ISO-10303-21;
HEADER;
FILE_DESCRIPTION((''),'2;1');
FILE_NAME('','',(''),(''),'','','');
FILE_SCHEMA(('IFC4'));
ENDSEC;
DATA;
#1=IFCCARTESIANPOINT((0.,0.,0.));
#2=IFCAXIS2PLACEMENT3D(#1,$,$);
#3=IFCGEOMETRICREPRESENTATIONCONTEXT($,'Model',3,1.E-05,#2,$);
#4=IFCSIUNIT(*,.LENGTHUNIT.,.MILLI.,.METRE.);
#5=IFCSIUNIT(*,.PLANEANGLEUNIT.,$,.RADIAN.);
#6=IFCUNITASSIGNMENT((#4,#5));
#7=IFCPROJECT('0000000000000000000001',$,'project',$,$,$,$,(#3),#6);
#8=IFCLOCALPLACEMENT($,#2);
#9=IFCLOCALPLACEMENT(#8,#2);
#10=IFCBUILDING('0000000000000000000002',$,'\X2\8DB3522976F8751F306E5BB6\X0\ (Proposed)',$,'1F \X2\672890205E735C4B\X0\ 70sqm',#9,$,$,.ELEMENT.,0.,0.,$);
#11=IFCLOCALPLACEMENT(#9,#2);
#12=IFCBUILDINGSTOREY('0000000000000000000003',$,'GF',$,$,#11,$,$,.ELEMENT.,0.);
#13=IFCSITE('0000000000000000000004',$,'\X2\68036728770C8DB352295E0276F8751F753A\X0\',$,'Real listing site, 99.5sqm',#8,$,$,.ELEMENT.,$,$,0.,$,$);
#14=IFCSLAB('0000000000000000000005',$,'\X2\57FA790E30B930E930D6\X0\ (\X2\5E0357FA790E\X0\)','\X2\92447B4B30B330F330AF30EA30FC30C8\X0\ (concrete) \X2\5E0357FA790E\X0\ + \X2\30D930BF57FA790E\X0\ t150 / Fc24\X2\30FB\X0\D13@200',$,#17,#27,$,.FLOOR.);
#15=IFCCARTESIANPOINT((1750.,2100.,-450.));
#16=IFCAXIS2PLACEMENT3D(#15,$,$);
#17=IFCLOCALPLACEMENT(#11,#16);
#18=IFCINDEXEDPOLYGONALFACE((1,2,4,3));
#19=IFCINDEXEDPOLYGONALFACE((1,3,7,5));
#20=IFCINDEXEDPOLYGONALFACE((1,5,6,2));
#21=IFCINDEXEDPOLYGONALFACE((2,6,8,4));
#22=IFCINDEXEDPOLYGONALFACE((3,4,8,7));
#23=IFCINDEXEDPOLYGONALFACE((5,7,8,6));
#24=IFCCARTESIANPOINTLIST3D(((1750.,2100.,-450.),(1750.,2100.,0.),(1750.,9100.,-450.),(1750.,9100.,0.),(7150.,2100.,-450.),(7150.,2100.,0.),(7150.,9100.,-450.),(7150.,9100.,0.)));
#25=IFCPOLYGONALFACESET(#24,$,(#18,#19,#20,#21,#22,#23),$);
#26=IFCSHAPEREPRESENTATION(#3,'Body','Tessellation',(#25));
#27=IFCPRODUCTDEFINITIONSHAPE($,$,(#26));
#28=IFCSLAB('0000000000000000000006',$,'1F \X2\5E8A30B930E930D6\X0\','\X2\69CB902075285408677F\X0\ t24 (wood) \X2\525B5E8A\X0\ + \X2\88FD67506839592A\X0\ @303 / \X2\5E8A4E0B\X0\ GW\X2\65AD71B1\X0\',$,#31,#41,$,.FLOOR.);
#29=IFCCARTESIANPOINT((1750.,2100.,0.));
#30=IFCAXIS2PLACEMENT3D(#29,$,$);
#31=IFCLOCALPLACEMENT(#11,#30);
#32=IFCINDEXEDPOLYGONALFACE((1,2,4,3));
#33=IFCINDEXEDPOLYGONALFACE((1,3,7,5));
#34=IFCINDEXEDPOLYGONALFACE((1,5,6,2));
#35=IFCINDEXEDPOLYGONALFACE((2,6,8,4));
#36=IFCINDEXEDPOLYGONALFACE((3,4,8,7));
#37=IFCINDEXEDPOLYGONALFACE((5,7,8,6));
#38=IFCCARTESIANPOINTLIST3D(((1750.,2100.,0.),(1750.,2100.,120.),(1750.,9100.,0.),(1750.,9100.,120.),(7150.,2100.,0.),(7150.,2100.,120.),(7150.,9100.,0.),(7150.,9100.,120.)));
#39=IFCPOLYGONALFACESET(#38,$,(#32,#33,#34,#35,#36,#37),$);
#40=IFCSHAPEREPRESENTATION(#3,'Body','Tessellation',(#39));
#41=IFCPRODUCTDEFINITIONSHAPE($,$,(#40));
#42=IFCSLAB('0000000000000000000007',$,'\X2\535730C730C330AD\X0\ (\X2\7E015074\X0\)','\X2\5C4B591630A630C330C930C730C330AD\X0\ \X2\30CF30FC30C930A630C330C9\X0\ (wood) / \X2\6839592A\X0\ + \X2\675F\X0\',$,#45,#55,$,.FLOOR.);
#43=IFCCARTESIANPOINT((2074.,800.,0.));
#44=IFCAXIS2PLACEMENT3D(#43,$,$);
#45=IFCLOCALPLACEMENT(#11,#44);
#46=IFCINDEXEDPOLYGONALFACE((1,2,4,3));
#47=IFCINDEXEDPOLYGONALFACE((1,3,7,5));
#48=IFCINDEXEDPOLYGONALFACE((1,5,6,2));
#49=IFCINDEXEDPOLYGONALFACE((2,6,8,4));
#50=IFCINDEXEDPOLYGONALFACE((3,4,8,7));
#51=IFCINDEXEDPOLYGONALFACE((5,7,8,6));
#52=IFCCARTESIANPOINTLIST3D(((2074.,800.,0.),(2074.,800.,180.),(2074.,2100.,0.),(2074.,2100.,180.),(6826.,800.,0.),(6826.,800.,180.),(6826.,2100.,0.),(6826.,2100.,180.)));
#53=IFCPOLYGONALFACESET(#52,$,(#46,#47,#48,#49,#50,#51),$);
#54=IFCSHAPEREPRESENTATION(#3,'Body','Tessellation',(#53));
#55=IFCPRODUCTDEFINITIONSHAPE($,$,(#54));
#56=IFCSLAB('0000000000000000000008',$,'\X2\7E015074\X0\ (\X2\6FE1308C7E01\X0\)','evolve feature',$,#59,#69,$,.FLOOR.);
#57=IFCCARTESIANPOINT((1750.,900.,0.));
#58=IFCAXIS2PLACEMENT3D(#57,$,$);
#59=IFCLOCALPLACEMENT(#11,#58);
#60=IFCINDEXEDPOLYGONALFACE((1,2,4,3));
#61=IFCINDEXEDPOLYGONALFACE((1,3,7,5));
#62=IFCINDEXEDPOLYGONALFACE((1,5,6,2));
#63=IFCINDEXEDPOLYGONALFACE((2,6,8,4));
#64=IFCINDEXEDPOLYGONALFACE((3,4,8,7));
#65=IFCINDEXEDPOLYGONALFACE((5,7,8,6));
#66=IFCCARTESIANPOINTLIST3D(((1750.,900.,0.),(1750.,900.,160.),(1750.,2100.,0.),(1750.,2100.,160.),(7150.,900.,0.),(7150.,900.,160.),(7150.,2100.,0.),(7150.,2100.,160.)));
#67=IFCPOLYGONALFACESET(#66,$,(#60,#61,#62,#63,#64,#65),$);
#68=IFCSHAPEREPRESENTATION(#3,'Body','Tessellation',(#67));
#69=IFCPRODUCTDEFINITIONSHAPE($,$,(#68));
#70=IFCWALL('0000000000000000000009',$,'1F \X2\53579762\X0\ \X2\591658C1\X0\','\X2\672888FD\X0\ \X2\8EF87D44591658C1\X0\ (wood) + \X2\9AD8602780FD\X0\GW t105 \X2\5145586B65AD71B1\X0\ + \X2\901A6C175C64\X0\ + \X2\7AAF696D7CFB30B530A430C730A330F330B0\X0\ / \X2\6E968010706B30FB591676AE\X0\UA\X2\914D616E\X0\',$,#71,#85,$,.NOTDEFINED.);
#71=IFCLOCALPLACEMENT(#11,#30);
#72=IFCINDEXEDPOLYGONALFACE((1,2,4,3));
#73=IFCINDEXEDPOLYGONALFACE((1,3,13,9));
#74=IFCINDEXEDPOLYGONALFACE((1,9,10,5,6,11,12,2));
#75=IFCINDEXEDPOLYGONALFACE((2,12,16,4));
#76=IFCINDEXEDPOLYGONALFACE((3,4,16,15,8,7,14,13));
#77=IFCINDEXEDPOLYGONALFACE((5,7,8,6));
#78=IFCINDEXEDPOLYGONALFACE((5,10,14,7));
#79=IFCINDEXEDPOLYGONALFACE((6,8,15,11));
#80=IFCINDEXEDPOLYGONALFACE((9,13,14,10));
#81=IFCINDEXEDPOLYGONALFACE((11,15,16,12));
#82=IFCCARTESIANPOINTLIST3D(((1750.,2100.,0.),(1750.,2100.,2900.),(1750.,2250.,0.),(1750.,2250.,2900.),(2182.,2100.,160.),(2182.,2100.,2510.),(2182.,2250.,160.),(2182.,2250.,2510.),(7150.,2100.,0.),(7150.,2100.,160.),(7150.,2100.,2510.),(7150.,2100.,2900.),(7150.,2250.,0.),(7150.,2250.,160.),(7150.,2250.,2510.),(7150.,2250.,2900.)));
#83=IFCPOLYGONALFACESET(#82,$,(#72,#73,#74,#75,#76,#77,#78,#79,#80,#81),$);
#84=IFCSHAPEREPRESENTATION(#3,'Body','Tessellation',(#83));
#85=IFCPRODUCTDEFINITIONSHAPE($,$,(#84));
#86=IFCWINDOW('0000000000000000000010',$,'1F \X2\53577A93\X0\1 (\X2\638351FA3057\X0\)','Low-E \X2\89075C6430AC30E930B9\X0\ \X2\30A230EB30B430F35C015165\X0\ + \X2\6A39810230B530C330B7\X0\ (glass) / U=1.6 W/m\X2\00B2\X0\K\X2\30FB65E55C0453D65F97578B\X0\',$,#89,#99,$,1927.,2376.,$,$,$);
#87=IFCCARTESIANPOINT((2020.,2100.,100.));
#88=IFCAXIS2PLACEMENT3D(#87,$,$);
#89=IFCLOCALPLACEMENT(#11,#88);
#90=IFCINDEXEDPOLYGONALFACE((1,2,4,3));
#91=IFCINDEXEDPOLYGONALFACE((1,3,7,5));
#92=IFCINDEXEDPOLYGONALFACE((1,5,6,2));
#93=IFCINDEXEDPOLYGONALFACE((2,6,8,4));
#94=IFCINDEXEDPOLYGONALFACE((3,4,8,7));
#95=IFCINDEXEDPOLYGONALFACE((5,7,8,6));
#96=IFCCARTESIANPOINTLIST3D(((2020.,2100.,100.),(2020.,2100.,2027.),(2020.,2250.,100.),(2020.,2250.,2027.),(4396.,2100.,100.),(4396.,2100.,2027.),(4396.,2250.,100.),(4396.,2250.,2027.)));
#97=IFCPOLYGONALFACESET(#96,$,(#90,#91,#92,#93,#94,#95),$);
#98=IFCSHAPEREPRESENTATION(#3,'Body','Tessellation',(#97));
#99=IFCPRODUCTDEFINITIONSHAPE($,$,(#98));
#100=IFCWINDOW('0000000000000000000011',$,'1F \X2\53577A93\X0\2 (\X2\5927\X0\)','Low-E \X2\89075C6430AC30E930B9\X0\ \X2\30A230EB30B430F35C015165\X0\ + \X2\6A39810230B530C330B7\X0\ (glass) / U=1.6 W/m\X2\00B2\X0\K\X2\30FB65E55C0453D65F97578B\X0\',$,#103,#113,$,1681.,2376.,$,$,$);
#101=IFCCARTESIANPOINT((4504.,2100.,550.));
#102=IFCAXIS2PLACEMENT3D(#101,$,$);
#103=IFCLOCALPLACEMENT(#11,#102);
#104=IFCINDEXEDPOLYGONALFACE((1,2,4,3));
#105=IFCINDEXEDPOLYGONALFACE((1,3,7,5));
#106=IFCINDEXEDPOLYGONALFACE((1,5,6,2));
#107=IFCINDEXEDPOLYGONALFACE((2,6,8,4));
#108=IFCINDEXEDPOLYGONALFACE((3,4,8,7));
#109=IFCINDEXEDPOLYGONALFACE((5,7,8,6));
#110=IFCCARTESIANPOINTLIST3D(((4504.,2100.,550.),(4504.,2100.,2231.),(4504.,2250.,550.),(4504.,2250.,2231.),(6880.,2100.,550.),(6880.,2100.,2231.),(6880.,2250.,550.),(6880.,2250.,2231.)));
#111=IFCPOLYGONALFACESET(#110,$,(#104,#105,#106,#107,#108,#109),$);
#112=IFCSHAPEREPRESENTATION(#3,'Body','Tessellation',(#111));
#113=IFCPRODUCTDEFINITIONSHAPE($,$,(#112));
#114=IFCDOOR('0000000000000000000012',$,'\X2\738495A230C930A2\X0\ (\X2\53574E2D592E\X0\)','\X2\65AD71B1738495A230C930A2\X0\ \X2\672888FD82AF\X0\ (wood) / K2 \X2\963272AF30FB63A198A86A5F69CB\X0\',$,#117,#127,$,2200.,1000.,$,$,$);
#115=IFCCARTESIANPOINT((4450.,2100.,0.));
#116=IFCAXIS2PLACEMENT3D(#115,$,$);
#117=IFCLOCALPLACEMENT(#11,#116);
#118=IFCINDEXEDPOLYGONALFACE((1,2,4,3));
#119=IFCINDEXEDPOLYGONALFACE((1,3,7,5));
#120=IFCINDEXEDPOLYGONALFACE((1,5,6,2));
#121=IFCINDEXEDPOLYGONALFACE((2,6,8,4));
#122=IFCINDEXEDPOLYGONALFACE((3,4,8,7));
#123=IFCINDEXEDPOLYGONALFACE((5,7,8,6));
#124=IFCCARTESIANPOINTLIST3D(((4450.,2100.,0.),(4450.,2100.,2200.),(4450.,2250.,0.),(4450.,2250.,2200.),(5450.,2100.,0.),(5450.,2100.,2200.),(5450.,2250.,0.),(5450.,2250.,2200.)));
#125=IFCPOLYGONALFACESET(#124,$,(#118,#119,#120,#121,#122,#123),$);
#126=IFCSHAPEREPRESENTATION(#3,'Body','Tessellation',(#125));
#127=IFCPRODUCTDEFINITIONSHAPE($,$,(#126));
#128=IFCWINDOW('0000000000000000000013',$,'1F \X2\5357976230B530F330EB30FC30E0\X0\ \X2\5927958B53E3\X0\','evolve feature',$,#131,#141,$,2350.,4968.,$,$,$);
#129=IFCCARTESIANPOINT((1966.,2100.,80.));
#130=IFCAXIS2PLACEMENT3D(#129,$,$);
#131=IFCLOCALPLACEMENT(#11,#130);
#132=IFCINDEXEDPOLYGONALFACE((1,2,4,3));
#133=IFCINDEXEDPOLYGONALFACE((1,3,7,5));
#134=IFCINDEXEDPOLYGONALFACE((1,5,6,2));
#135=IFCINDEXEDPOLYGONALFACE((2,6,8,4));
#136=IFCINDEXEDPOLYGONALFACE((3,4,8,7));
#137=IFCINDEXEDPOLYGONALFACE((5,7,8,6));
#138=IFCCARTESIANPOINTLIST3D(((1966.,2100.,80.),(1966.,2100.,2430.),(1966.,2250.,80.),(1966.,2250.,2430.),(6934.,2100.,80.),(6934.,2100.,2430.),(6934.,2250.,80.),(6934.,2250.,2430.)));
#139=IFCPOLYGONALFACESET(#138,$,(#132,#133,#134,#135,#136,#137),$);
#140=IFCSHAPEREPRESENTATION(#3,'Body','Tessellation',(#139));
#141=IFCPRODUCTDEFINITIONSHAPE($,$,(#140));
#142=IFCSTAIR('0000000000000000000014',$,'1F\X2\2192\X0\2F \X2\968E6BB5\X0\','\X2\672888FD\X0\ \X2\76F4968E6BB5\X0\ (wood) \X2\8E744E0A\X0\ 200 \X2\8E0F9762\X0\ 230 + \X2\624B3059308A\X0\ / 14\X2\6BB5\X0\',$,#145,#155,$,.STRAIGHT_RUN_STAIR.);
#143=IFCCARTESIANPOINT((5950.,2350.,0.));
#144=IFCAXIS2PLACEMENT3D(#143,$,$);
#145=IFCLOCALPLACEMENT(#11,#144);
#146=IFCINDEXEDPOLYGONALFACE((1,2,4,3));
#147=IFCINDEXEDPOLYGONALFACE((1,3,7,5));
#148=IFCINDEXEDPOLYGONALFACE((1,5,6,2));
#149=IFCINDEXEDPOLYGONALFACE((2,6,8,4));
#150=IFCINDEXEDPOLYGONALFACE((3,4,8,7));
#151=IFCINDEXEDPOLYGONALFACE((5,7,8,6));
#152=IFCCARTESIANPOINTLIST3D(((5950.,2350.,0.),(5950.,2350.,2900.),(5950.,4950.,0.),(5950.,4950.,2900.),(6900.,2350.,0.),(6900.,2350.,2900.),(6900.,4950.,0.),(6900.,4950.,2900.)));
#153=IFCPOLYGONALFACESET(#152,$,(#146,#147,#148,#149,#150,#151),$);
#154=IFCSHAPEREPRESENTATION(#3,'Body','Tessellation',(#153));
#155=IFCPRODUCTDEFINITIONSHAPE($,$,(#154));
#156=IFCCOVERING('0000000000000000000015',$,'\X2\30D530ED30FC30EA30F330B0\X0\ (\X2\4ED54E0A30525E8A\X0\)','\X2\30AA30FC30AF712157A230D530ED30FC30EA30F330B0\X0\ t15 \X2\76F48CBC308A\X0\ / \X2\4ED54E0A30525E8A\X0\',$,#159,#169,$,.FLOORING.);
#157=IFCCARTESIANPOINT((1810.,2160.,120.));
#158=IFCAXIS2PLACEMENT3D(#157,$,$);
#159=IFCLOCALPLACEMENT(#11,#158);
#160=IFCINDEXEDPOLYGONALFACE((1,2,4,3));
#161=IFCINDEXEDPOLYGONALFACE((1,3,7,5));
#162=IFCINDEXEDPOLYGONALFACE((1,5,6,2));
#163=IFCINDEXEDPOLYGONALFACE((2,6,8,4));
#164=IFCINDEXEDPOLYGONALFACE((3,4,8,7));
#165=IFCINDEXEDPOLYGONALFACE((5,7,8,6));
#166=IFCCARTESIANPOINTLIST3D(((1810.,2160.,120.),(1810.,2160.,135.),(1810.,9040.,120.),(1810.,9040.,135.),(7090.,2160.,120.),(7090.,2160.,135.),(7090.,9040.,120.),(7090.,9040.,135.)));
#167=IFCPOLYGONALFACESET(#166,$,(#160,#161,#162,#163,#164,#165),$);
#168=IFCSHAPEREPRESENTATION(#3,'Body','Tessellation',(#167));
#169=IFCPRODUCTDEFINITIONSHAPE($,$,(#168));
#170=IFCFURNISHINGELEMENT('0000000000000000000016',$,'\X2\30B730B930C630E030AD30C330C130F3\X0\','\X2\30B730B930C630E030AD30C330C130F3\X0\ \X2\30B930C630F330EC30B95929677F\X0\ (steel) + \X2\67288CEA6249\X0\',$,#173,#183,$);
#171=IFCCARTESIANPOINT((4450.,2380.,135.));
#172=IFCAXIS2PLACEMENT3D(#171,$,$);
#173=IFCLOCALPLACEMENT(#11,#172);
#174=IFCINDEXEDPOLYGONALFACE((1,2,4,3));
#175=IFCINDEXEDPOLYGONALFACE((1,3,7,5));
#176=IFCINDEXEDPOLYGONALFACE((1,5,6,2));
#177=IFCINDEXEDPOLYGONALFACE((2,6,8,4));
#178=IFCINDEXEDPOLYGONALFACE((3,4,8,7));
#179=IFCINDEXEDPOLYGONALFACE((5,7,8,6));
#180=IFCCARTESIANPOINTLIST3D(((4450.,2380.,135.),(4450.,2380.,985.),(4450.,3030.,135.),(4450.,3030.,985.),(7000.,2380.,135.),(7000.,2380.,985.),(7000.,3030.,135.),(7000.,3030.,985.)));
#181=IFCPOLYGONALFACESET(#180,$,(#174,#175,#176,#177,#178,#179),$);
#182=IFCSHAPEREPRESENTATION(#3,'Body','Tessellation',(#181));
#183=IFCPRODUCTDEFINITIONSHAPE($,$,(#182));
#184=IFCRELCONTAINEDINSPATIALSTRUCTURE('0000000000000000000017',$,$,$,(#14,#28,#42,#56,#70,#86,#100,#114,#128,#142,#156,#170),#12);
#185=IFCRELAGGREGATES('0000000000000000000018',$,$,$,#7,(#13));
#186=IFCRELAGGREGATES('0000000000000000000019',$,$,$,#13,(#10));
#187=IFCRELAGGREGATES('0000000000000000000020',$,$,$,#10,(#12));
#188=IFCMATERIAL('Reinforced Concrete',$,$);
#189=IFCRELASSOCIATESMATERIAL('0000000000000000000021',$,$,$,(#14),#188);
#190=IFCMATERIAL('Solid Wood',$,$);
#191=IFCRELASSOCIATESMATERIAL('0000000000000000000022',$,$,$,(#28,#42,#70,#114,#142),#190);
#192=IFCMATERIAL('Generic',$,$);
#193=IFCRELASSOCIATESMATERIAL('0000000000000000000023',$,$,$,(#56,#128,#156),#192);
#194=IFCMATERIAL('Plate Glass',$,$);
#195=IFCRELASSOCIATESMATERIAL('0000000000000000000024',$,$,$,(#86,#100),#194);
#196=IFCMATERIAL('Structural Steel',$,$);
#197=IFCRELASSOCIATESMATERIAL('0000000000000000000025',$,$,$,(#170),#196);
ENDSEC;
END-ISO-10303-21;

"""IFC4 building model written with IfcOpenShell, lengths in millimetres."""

from ifc_helpers import new_model, si_unit, frame, frame_2d, origin, place, context, project, spatial, rectangle, extrude, material, element, fill, save


model = new_model("IFC4")

# Units and contexts
model_context = context("Model", 3, precision=1e-05, world=origin())
ifc_project = project(units=[si_unit("LENGTHUNIT", "METRE", prefix="MILLI"), si_unit("PLANEANGLEUNIT", "RADIAN")], contexts=[model_context])

# Site, building, storey
site_placement = place(None, origin())
site = spatial("IfcSite", under=ifc_project, at=site_placement, Name="栃木県足利市相生町", ObjectType="Real listing site, 99.5sqm", CompositionType="ELEMENT", RefElevation=0.0)
building_placement = place(site_placement, origin())
building = spatial("IfcBuilding", under=site, at=building_placement, Name="足利相生の家 (Proposed)", ObjectType="1F 木造平屋 70sqm", CompositionType="ELEMENT", ElevationOfRefHeight=0.0, ElevationOfTerrain=0.0)
storey_placement = place(building_placement, origin())
storey = spatial("IfcBuildingStorey", under=building, at=storey_placement, Name="GF", CompositionType="ELEMENT", Elevation=0.0)

# Slabs
ifc_material_1 = material(Name="Reinforced Concrete")
slab_1_placement = place(storey_placement, frame((1750.0, 2100.0, -450.0)))
element("IfcSlab", 1, at=slab_1_placement, inside=storey, material=ifc_material_1, Name="基礎スラブ (布基礎)", Description="鉄筋コンクリート (concrete) 布基礎 + ベタ基礎 t150 / Fc24・D13@200", PredefinedType="FLOOR", context=model_context, shape_type="SweptSolid", body=[
    extrude(rectangle(XDim=5400.0, YDim=7000.0, at=frame_2d((2700.0, 3500.0))), frame((1750.0, 2100.0, -450.0)), (0.0, 0.0, 1.0), 450.0),
])
ifc_material_2 = material(Name="Solid Wood")
slab_2_placement = place(storey_placement, frame((1750.0, 2100.0, 0.0)))
element("IfcSlab", 2, at=slab_2_placement, inside=storey, material=ifc_material_2, Name="1F 床スラブ", Description="構造用合板 t24 (wood) 剛床 + 製材根太 @303 / 床下 GW断熱", PredefinedType="FLOOR", context=model_context, shape_type="SweptSolid", body=[
    extrude(rectangle(XDim=5400.0, YDim=7000.0, at=frame_2d((2700.0, 3500.0))), frame((1750.0, 2100.0, 0.0)), (0.0, 0.0, 1.0), 120.0),
])
slab_3_placement = place(storey_placement, frame((2074.0, 800.0, 0.0)))
element("IfcSlab", 3, at=slab_3_placement, inside=storey, material=ifc_material_2, Name="南デッキ (縁側)", Description="屋外ウッドデッキ ハードウッド (wood) / 根太 + 束", PredefinedType="FLOOR", context=model_context, shape_type="SweptSolid", body=[
    extrude(rectangle(XDim=4752.0, YDim=1300.0, at=frame_2d((2376.0, 650.0))), frame((2074.0, 800.0, 0.0)), (0.0, 0.0, 1.0), 180.0),
])
ifc_material_3 = material(Name="Generic")
slab_4_placement = place(storey_placement, frame((1750.0, 900.0, 0.0)))
element("IfcSlab", 4, at=slab_4_placement, inside=storey, material=ifc_material_3, Name="縁側 (濡れ縁)", Description="evolve feature", PredefinedType="FLOOR", context=model_context, shape_type="SweptSolid", body=[
    extrude(rectangle(XDim=5400.0, YDim=1200.0, at=frame_2d((2700.0, 600.0))), frame((1750.0, 900.0, 0.0)), (0.0, 0.0, 1.0), 160.0),
])

# Wall, openings, windows, door
wall_1_placement = place(storey_placement, frame((1750.0, 2100.0, 0.0)))
wall_1 = element("IfcWall", 5, at=wall_1_placement, inside=storey, material=ifc_material_2, Name="1F 南面 外壁", Description="木製 軸組外壁 (wood) + 高性能GW t105 充填断熱 + 通気層 + 窯業系サイディング / 準耐火・外皮UA配慮", PredefinedType="NOTDEFINED", context=model_context, shape_type="SweptSolid", body=[
    extrude(rectangle(XDim=5400.0, YDim=150.0, at=frame_2d((2700.0, 75.0))), frame((1750.0, 2100.0, 0.0)), (0.0, 0.0, 1.0), 2900.0),
])
opening_1_placement = place(storey_placement, frame((2020.0, 2100.0, 100.0)))
opening_1 = element("IfcOpeningElement", 6, at=opening_1_placement, cuts=wall_1, PredefinedType="NOTDEFINED", context=model_context, shape_type="SweptSolid", body=[
    extrude(rectangle(XDim=2376.0, YDim=150.0, at=frame_2d((1188.0, 75.0))), frame((2020.0, 2100.0, 100.0)), (0.0, 0.0, 1.0), 1927.0),
])
opening_2_placement = place(storey_placement, frame((4504.0, 2100.0, 550.0)))
opening_2 = element("IfcOpeningElement", 7, at=opening_2_placement, cuts=wall_1, PredefinedType="NOTDEFINED", context=model_context, shape_type="SweptSolid", body=[
    extrude(rectangle(XDim=2376.0, YDim=150.0, at=frame_2d((1188.0, 75.0))), frame((4504.0, 2100.0, 550.0)), (0.0, 0.0, 1.0), 1681.0),
])
opening_3_placement = place(storey_placement, frame((4450.0, 2100.0, 0.0)))
opening_3 = element("IfcOpeningElement", 8, at=opening_3_placement, cuts=wall_1, PredefinedType="NOTDEFINED", context=model_context, shape_type="SweptSolid", body=[
    extrude(rectangle(XDim=1000.0, YDim=150.0, at=frame_2d((500.0, 75.0))), frame((4450.0, 2100.0, 0.0)), (0.0, 0.0, 1.0), 2200.0),
])
opening_4_placement = place(storey_placement, frame((1966.0, 2100.0, 80.0)))
opening_4 = element("IfcOpeningElement", 9, at=opening_4_placement, cuts=wall_1, PredefinedType="NOTDEFINED", context=model_context, shape_type="SweptSolid", body=[
    extrude(rectangle(XDim=4968.0, YDim=150.0, at=frame_2d((2484.0, 75.0))), frame((1966.0, 2100.0, 80.0)), (0.0, 0.0, 1.0), 2350.0),
])
ifc_material_4 = material(Name="Plate Glass")
window_1_placement = place(storey_placement, frame((2020.0, 2100.0, 100.0)))
window_1 = element("IfcWindow", 10, at=window_1_placement, inside=storey, material=ifc_material_4, Name="1F 南窓1 (掃出し)", Description="Low-E 複層ガラス アルゴン封入 + 樹脂サッシ (glass) / U=1.6 W/m²K・日射取得型", OverallHeight=1927.0, OverallWidth=2376.0, context=model_context, shape_type="SweptSolid", body=[
    extrude(rectangle(XDim=2376.0, YDim=150.0, at=frame_2d((1188.0, 75.0))), frame((2020.0, 2100.0, 100.0)), (0.0, 0.0, 1.0), 1927.0),
])
fill(opening_1, window_1)
window_2_placement = place(storey_placement, frame((4504.0, 2100.0, 550.0)))
window_2 = element("IfcWindow", 11, at=window_2_placement, inside=storey, material=ifc_material_4, Name="1F 南窓2 (大)", Description="Low-E 複層ガラス アルゴン封入 + 樹脂サッシ (glass) / U=1.6 W/m²K・日射取得型", OverallHeight=1681.0, OverallWidth=2376.0, context=model_context, shape_type="SweptSolid", body=[
    extrude(rectangle(XDim=2376.0, YDim=150.0, at=frame_2d((1188.0, 75.0))), frame((4504.0, 2100.0, 550.0)), (0.0, 0.0, 1.0), 1681.0),
])
fill(opening_2, window_2)
door_placement = place(storey_placement, frame((4450.0, 2100.0, 0.0)))
door = element("IfcDoor", 12, at=door_placement, inside=storey, material=ifc_material_2, Name="玄関ドア (南中央)", Description="断熱玄関ドア 木製芯 (wood) / K2 防犯・採風機構", OverallHeight=2200.0, OverallWidth=1000.0, context=model_context, shape_type="SweptSolid", body=[
    extrude(rectangle(XDim=1000.0, YDim=150.0, at=frame_2d((500.0, 75.0))), frame((4450.0, 2100.0, 0.0)), (0.0, 0.0, 1.0), 2200.0),
])
fill(opening_3, door)
window_3_placement = place(storey_placement, frame((1966.0, 2100.0, 80.0)))
window_3 = element("IfcWindow", 13, at=window_3_placement, inside=storey, material=ifc_material_3, Name="1F 南面サンルーム 大開口", Description="evolve feature", OverallHeight=2350.0, OverallWidth=4968.0, context=model_context, shape_type="SweptSolid", body=[
    extrude(rectangle(XDim=4968.0, YDim=150.0, at=frame_2d((2484.0, 75.0))), frame((1966.0, 2100.0, 80.0)), (0.0, 0.0, 1.0), 2350.0),
])
fill(opening_4, window_3)

# Stair
stair_placement = place(storey_placement, frame((5950.0, 2350.0, 0.0)))
element("IfcStair", 14, at=stair_placement, inside=storey, material=ifc_material_2, Name="1F→2F 階段", Description="木製 直階段 (wood) 蹴上 200 踏面 230 + 手すり / 14段", PredefinedType="STRAIGHT_RUN_STAIR", context=model_context, shape_type="SweptSolid", body=[
    extrude(rectangle(XDim=950.0, YDim=2600.0, at=frame_2d((475.0, 1300.0))), frame((5950.0, 2350.0, 0.0)), (0.0, 0.0, 1.0), 2900.0),
])

# Covering
covering_placement = place(storey_placement, frame((1810.0, 2160.0, 120.0)))
element("IfcCovering", 15, at=covering_placement, inside=storey, material=ifc_material_3, Name="フローリング (仕上げ床)", Description="オーク無垢フローリング t15 直貼り / 仕上げ床", PredefinedType="FLOORING", context=model_context, shape_type="SweptSolid", body=[
    extrude(rectangle(XDim=5280.0, YDim=6880.0, at=frame_2d((2640.0, 3440.0))), frame((1810.0, 2160.0, 120.0)), (0.0, 0.0, 1.0), 15.0),
])

# Furnishing element
ifc_material_5 = material(Name="Structural Steel")
furnishing_placement = place(storey_placement, frame((4450.0, 2380.0, 135.0)))
element("IfcFurnishingElement", 16, at=furnishing_placement, inside=storey, material=ifc_material_5, Name="システムキッチン", Description="システムキッチン ステンレス天板 (steel) + 木質扉", context=model_context, shape_type="SweptSolid", body=[
    extrude(rectangle(XDim=2550.0, YDim=650.0, at=frame_2d((1275.0, 325.0))), frame((4450.0, 2380.0, 135.0)), (0.0, 0.0, 1.0), 850.0),
])

save(model, "model.ifc")
